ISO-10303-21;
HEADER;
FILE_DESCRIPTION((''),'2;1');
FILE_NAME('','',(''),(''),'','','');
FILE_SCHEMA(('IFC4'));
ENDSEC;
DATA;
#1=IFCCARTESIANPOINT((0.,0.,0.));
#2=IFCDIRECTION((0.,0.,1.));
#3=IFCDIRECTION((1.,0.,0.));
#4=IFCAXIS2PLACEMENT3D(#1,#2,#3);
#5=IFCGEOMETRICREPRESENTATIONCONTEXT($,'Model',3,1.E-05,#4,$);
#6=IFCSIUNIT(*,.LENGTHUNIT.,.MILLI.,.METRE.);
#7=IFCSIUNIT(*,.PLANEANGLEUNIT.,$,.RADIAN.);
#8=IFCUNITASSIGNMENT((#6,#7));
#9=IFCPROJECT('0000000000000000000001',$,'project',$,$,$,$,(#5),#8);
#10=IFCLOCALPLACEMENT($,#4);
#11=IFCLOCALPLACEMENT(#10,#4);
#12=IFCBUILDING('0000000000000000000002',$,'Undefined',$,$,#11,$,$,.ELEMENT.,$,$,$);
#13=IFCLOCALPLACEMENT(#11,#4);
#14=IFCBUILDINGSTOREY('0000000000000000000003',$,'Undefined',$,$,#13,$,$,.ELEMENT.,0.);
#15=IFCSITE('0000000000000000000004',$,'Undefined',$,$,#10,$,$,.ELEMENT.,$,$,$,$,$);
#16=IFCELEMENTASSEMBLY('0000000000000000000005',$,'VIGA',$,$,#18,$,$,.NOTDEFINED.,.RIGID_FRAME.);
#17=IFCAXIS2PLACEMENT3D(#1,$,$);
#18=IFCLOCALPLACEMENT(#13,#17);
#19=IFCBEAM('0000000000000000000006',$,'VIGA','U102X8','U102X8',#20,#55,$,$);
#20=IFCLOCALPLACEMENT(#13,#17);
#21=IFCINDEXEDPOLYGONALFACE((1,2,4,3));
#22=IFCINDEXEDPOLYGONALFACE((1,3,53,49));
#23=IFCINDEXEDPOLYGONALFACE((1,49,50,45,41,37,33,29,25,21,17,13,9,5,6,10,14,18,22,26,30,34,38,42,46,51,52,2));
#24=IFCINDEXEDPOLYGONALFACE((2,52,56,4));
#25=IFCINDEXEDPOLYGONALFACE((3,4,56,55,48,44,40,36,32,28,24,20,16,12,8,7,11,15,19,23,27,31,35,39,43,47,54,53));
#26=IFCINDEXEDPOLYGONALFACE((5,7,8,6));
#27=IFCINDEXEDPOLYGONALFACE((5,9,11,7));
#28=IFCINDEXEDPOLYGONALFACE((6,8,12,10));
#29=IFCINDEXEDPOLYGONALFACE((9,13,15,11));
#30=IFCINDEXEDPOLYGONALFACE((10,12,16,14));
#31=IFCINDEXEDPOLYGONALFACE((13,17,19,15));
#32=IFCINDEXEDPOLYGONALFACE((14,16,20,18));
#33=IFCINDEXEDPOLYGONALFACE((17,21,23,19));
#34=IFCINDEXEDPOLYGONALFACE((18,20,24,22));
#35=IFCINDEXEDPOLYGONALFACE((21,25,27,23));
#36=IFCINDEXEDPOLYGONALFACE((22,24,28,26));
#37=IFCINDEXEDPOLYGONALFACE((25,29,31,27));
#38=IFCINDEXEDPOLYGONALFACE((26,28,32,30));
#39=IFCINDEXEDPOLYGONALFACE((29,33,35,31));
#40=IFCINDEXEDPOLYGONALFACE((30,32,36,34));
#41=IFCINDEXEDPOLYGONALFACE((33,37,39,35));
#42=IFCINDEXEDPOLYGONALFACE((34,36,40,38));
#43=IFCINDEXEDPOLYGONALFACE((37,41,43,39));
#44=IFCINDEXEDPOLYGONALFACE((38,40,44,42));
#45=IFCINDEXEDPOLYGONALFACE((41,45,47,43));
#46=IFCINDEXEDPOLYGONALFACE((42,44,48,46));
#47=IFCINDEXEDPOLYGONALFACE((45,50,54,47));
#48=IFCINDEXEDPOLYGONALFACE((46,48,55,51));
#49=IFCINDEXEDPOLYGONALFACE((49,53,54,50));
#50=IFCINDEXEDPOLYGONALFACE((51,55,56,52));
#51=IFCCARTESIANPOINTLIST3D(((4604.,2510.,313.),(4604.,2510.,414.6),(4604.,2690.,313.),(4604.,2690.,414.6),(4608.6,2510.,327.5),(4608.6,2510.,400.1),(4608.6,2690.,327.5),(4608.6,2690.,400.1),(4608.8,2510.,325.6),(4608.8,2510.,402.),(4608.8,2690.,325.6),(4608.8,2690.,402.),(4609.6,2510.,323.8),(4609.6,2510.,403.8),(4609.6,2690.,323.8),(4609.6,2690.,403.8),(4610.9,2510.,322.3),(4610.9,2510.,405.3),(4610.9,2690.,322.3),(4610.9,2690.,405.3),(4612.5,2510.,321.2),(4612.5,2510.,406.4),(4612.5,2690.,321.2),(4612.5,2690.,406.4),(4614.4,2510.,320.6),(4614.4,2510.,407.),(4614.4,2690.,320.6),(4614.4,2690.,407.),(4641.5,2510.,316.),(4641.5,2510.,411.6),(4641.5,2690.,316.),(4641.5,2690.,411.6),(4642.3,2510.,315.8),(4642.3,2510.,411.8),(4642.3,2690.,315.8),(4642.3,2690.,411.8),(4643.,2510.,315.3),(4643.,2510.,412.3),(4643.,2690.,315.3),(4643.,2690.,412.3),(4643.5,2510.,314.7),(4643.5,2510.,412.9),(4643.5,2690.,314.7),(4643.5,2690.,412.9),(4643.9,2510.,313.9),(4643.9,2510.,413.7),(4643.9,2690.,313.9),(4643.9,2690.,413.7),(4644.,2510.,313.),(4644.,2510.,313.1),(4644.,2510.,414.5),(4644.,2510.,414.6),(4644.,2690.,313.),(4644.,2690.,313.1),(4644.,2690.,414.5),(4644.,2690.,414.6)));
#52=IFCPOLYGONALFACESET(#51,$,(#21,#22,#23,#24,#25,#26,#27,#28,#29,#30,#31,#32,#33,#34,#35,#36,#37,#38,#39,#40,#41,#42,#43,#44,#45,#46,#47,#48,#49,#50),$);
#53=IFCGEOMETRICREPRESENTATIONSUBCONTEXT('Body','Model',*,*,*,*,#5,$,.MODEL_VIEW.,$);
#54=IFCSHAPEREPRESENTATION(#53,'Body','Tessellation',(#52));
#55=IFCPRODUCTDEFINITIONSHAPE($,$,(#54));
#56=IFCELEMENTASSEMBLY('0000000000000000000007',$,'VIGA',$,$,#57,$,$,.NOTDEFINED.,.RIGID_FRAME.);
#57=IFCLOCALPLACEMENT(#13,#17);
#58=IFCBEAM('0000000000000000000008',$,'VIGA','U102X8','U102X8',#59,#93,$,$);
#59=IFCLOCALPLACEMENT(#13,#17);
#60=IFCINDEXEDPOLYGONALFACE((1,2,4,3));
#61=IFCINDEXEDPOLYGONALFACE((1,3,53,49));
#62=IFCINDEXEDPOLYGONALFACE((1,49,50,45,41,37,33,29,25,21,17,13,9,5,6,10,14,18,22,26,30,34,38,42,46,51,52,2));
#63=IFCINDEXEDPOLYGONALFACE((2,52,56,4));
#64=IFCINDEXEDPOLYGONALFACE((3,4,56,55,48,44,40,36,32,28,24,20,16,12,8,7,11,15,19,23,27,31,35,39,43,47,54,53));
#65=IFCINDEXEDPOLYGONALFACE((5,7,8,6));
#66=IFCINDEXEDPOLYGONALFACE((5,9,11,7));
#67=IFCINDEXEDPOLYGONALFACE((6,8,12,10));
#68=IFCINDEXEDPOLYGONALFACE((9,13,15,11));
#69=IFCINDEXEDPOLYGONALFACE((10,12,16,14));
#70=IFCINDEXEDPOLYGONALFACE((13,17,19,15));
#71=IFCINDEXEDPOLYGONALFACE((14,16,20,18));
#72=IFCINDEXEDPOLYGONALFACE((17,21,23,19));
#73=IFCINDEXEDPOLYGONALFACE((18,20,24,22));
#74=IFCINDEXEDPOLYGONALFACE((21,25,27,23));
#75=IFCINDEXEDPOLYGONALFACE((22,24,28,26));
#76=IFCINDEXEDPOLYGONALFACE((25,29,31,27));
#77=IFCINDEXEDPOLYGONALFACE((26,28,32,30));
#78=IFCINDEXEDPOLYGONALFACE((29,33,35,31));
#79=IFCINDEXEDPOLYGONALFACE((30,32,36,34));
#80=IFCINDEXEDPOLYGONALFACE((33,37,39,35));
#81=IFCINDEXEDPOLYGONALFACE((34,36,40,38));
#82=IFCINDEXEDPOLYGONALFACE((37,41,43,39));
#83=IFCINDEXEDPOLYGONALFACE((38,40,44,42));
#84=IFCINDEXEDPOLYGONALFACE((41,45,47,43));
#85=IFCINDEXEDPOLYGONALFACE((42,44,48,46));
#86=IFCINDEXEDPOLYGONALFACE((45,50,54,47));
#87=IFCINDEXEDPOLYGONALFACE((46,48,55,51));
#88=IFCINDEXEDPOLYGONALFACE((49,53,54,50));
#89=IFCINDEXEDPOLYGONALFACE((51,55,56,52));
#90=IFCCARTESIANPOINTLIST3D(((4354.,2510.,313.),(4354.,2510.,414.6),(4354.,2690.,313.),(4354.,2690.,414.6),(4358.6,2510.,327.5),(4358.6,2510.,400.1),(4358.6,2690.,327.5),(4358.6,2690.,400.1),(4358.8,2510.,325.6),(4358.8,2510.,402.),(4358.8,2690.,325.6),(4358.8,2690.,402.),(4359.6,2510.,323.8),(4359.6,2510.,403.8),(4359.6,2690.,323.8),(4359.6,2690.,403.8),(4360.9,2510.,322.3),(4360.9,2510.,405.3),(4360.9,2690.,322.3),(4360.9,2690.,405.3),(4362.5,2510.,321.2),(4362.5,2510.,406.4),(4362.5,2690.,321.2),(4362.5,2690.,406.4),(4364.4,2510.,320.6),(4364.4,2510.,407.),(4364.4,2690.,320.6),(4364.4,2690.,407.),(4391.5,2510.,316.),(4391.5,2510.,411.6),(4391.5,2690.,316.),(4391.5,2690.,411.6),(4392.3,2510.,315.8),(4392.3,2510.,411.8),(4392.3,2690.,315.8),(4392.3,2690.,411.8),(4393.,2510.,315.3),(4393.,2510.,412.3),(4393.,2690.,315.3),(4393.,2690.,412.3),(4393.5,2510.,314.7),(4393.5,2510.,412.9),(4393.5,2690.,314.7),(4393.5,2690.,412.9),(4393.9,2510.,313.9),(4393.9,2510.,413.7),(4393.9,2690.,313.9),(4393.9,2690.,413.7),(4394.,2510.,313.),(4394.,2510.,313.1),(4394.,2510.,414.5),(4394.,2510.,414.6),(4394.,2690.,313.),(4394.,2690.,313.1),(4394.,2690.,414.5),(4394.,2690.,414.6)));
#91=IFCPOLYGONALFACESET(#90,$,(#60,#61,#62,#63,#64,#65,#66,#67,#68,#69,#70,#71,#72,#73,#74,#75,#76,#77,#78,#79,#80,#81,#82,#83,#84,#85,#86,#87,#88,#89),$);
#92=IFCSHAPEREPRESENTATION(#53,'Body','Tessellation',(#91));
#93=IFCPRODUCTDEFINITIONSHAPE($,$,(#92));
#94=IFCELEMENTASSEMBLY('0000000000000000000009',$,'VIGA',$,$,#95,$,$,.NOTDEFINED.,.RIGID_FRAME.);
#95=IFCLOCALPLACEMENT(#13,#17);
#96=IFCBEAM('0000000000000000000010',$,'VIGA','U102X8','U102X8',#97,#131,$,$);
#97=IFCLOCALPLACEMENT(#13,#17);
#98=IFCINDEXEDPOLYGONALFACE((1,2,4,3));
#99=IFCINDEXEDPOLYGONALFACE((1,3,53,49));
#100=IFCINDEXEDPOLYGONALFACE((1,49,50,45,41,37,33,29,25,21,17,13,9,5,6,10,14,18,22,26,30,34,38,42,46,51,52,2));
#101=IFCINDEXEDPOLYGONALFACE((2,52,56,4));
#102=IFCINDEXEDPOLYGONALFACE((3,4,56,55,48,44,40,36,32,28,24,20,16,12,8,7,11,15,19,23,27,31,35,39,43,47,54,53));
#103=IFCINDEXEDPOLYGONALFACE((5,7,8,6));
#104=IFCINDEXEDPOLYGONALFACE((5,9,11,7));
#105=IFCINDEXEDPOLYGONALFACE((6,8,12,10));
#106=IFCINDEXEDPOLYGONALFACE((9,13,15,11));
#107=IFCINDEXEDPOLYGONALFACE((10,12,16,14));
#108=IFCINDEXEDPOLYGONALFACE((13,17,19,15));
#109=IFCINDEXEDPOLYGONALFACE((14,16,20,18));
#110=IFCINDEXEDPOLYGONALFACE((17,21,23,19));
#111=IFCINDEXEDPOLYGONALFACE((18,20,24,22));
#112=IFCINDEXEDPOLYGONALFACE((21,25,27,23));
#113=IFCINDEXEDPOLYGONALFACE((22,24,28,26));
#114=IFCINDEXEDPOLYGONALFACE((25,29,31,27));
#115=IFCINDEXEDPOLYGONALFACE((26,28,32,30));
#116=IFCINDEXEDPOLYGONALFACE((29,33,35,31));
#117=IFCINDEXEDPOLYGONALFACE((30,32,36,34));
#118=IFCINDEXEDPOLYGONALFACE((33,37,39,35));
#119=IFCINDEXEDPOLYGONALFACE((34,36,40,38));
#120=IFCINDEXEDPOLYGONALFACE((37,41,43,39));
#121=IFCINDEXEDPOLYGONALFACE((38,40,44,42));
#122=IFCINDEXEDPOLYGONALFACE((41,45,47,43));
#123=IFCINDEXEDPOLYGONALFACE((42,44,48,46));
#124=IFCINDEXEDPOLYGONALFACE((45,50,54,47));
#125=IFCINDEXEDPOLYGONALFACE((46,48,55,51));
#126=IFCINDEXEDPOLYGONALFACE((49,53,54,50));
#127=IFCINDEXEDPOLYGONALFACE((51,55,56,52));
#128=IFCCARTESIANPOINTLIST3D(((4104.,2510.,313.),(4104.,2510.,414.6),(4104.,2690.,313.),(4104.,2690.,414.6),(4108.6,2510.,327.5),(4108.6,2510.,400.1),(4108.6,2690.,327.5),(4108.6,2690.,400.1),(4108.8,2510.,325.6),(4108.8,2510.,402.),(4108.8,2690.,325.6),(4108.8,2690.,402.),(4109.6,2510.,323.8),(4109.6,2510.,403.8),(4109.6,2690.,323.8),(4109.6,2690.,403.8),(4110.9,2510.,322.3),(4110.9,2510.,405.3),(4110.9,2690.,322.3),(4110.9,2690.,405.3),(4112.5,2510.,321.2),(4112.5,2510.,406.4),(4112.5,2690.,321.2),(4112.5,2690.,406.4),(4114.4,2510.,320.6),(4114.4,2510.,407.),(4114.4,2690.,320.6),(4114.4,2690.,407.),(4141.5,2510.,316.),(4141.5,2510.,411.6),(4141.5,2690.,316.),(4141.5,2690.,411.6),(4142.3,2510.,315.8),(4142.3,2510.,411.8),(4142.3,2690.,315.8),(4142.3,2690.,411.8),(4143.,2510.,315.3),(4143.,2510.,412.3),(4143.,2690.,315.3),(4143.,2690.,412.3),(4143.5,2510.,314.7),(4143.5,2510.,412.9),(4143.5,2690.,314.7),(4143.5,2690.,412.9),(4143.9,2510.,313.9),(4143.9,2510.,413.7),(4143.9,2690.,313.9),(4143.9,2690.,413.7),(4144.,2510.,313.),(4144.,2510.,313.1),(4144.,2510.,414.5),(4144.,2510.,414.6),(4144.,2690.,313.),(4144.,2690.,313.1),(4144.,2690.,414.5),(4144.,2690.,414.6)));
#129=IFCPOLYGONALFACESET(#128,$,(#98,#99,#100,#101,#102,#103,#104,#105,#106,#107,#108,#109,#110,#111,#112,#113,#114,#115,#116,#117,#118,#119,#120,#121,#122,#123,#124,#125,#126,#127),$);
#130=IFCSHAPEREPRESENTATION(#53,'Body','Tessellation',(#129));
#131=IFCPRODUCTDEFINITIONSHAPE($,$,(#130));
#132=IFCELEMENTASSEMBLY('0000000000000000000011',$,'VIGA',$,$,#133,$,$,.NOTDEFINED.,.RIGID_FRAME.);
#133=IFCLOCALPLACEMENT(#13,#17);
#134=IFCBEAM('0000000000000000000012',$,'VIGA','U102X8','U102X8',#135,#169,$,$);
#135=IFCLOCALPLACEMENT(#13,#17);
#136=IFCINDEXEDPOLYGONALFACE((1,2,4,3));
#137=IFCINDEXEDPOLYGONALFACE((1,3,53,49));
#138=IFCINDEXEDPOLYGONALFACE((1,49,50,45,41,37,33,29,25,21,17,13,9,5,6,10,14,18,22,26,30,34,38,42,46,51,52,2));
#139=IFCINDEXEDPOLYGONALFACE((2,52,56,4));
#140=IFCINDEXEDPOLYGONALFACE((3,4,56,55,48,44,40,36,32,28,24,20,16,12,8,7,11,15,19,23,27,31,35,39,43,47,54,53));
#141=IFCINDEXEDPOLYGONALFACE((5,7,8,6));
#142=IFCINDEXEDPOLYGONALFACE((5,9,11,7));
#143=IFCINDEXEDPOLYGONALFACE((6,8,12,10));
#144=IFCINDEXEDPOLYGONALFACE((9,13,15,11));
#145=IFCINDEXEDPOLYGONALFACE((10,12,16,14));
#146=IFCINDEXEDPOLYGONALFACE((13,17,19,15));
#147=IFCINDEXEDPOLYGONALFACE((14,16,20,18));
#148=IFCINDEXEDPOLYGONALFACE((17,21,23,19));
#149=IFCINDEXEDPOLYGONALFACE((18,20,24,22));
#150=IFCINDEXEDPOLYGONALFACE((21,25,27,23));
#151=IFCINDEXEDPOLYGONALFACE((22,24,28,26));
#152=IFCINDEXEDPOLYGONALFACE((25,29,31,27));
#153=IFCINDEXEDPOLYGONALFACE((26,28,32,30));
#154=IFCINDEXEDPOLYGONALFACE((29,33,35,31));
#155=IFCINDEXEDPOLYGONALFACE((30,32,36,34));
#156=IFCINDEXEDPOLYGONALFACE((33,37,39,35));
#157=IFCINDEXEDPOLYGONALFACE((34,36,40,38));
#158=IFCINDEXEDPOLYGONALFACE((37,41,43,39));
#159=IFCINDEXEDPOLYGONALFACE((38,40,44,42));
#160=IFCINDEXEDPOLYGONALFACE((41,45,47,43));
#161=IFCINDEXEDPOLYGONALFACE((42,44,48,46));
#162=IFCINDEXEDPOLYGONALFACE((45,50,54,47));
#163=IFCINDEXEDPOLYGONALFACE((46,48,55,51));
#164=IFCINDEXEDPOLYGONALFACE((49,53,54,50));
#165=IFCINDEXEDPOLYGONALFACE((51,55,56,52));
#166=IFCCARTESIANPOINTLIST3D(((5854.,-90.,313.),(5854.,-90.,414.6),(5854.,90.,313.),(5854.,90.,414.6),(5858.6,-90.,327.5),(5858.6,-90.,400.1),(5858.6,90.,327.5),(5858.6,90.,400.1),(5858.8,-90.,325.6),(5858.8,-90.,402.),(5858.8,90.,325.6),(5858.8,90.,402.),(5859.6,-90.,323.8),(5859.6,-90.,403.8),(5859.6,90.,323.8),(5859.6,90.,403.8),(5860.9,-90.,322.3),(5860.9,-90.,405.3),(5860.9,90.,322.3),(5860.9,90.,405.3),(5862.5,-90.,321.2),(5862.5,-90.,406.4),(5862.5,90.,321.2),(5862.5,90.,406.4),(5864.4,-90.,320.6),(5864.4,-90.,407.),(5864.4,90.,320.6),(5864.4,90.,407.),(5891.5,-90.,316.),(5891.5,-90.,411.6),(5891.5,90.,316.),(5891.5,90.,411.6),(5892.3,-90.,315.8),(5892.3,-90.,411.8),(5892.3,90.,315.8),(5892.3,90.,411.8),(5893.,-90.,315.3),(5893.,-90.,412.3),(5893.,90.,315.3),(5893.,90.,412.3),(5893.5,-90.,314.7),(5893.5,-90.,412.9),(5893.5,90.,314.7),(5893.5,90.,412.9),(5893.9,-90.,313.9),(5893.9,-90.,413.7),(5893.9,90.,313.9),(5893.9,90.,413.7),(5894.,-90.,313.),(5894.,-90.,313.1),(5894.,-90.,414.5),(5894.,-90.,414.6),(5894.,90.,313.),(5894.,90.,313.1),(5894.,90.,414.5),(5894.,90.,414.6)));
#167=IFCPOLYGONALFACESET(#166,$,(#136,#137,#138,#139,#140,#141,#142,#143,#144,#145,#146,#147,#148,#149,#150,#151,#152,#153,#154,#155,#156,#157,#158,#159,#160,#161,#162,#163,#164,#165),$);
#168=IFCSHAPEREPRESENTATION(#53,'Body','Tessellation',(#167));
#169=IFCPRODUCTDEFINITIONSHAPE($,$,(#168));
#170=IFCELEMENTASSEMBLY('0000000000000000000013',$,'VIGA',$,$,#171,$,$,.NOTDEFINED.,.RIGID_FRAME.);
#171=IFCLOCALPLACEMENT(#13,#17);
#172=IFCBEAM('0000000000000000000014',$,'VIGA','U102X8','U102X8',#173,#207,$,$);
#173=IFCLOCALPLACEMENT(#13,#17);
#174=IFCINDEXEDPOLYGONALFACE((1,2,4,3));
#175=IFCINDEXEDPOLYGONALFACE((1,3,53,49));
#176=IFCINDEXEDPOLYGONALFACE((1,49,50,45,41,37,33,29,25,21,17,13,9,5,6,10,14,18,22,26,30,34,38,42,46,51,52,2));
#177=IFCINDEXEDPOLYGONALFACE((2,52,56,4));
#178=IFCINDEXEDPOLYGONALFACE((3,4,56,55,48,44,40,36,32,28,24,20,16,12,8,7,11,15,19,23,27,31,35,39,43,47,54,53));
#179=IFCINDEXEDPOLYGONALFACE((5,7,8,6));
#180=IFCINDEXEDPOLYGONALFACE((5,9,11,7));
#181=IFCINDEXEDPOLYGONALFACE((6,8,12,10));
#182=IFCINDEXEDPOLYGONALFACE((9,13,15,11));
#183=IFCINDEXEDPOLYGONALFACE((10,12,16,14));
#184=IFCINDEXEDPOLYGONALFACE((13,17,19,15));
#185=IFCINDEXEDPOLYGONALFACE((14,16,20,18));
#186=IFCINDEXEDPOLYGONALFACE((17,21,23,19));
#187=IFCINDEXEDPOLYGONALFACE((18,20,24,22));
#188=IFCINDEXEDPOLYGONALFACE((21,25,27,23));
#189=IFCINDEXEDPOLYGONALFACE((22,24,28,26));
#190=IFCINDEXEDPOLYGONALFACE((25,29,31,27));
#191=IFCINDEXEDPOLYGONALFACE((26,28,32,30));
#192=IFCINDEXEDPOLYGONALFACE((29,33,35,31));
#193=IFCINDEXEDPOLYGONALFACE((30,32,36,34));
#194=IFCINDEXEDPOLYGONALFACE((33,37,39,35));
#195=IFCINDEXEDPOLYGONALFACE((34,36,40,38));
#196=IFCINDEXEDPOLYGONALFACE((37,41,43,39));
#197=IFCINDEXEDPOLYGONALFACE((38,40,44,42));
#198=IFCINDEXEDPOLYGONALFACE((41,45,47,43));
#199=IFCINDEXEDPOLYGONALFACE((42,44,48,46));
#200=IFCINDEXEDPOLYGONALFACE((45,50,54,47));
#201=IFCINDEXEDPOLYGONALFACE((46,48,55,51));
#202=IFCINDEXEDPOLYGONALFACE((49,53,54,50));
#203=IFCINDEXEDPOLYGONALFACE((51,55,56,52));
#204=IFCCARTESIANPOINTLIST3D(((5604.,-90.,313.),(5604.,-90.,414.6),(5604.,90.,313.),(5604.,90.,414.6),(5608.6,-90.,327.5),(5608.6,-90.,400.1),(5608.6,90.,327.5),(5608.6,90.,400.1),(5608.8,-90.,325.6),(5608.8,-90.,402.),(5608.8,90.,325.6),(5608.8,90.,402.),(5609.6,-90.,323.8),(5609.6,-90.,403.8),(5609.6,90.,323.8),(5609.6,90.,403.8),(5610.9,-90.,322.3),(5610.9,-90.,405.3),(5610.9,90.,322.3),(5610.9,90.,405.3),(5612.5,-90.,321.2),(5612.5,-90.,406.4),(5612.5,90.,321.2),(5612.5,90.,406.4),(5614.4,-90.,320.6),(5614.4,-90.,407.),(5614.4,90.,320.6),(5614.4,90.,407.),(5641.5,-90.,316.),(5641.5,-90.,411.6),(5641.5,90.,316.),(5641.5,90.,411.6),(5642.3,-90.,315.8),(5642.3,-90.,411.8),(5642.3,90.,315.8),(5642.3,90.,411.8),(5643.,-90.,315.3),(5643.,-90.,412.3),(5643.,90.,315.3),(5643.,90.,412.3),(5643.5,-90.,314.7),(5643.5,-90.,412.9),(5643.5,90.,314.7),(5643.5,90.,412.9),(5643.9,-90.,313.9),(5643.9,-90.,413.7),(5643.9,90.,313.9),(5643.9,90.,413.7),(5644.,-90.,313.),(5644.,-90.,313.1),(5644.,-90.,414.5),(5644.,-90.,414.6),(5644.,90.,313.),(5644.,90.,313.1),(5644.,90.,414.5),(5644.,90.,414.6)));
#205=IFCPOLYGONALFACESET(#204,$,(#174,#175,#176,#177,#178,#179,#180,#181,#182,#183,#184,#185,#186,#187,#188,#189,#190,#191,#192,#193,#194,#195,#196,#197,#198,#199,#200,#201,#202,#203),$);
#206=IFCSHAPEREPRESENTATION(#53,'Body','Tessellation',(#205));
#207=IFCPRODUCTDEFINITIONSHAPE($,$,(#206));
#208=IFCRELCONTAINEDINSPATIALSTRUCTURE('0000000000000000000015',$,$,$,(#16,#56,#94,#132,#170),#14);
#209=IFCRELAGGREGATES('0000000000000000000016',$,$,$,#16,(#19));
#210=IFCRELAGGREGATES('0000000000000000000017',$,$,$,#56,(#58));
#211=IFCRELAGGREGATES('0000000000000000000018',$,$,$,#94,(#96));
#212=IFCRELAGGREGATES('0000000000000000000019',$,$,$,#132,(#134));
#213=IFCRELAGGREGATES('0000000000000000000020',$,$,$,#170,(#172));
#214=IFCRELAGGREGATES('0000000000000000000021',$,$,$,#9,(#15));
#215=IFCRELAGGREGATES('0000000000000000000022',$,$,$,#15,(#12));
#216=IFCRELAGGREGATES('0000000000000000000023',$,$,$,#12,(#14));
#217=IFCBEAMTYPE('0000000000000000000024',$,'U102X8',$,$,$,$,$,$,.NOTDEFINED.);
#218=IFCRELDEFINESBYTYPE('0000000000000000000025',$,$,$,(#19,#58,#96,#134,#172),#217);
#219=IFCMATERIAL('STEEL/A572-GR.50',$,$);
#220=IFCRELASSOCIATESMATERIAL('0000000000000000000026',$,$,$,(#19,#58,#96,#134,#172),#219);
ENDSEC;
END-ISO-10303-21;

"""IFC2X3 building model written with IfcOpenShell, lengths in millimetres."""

from ifc_helpers import new_model, si_unit, frame, origin_with_axes, origin_2d_with_axis, place, context, subcontext, project, spatial, u_section, extrude, material, type_object, element, aggregate, save


model = new_model("IFC2X3")

# Units and contexts
model_context = context("Model", 3, precision=1e-05, world=origin_with_axes())
body_context = subcontext(model_context, "Body", "Model", "MODEL_VIEW")
ifc_project = project(units=[si_unit("LENGTHUNIT", "METRE", prefix="MILLI"), si_unit("PLANEANGLEUNIT", "RADIAN")], contexts=[model_context])

# Site, building, storey
site_placement = place(None, origin_with_axes())
site = spatial("IfcSite", under=ifc_project, at=site_placement, Name="Undefined", CompositionType="ELEMENT")
building_placement = place(site_placement, origin_with_axes())
building = spatial("IfcBuilding", under=site, at=building_placement, Name="Undefined", CompositionType="ELEMENT")
storey_placement = place(building_placement, origin_with_axes())
storey = spatial("IfcBuildingStorey", under=building, at=storey_placement, Name="Undefined", CompositionType="ELEMENT", Elevation=0.0)

# Element assemblies, beams
ifc_material = material(Name="STEEL/A572-GR.50")
beam_type = type_object("IfcBeamType", Name="U102X8", PredefinedType="NOTDEFINED")
assembly_1_placement = place(storey_placement, origin_with_axes())
assembly_1 = element("IfcElementAssembly", 1, at=assembly_1_placement, inside=storey, Name="VIGA", AssemblyPlace="NOTDEFINED", PredefinedType="RIGID_FRAME")
beam_1_placement = place(assembly_1_placement, frame((4624.0, 2510.0, 363.8), z_axis=(0.0, 0.0, 1.0), x_axis=(0.0, 1.0, 0.0)))
beam_1 = element("IfcBeam", 2, at=beam_1_placement, type_object=beam_type, material=ifc_material, Name="VIGA", Description="U102X8", ObjectType="U102X8", context=body_context, shape_type="SweptSolid", body=[
    extrude(u_section(Depth=101.6, FlangeWidth=40.0, WebThickness=4.6, FlangeThickness=6.0, FilletRadius=7.0, EdgeRadius=3.0, FlangeSlope=0.16839, at=origin_2d_with_axis()), frame((180.0, 0.0, 0.0), z_axis=(-1.0, 0.0, 0.0), x_axis=(0.0, -1.0, 0.0)), (0.0, 0.0, 1.0), 180.0),
])
aggregate(assembly_1, [beam_1])
assembly_2_placement = place(storey_placement, origin_with_axes())
assembly_2 = element("IfcElementAssembly", 3, at=assembly_2_placement, inside=storey, Name="VIGA", AssemblyPlace="NOTDEFINED", PredefinedType="RIGID_FRAME")
beam_2_placement = place(assembly_2_placement, frame((4374.0, 2510.0, 363.8), z_axis=(0.0, 0.0, 1.0), x_axis=(0.0, 1.0, 0.0)))
beam_2 = element("IfcBeam", 4, at=beam_2_placement, type_object=beam_type, material=ifc_material, Name="VIGA", Description="U102X8", ObjectType="U102X8", context=body_context, shape_type="SweptSolid", body=[
    extrude(u_section(Depth=101.6, FlangeWidth=40.0, WebThickness=4.6, FlangeThickness=6.0, FilletRadius=7.0, EdgeRadius=3.0, FlangeSlope=0.16839, at=origin_2d_with_axis()), frame((180.0, 0.0, 0.0), z_axis=(-1.0, 0.0, 0.0), x_axis=(0.0, -1.0, 0.0)), (0.0, 0.0, 1.0), 180.0),
])
aggregate(assembly_2, [beam_2])
assembly_3_placement = place(storey_placement, origin_with_axes())
assembly_3 = element("IfcElementAssembly", 5, at=assembly_3_placement, inside=storey, Name="VIGA", AssemblyPlace="NOTDEFINED", PredefinedType="RIGID_FRAME")
beam_3_placement = place(assembly_3_placement, frame((4124.0, 2510.0, 363.8), z_axis=(0.0, 0.0, 1.0), x_axis=(0.0, 1.0, 0.0)))
beam_3 = element("IfcBeam", 6, at=beam_3_placement, type_object=beam_type, material=ifc_material, Name="VIGA", Description="U102X8", ObjectType="U102X8", context=body_context, shape_type="SweptSolid", body=[
    extrude(u_section(Depth=101.6, FlangeWidth=40.0, WebThickness=4.6, FlangeThickness=6.0, FilletRadius=7.0, EdgeRadius=3.0, FlangeSlope=0.16839, at=origin_2d_with_axis()), frame((180.0, 0.0, 0.0), z_axis=(-1.0, 0.0, 0.0), x_axis=(0.0, -1.0, 0.0)), (0.0, 0.0, 1.0), 180.0),
])
aggregate(assembly_3, [beam_3])
assembly_4_placement = place(storey_placement, origin_with_axes())
assembly_4 = element("IfcElementAssembly", 7, at=assembly_4_placement, inside=storey, Name="VIGA", AssemblyPlace="NOTDEFINED", PredefinedType="RIGID_FRAME")
beam_4_placement = place(assembly_4_placement, frame((5874.0, -90.0, 363.8), z_axis=(0.0, 0.0, 1.0), x_axis=(0.0, 1.0, 0.0)))
beam_4 = element("IfcBeam", 8, at=beam_4_placement, type_object=beam_type, material=ifc_material, Name="VIGA", Description="U102X8", ObjectType="U102X8", context=body_context, shape_type="SweptSolid", body=[
    extrude(u_section(Depth=101.6, FlangeWidth=40.0, WebThickness=4.6, FlangeThickness=6.0, FilletRadius=7.0, EdgeRadius=3.0, FlangeSlope=0.16839, at=origin_2d_with_axis()), frame((180.0, 0.0, 0.0), z_axis=(-1.0, 0.0, 0.0), x_axis=(0.0, -1.0, 0.0)), (0.0, 0.0, 1.0), 180.0),
])
aggregate(assembly_4, [beam_4])
assembly_5_placement = place(storey_placement, origin_with_axes())
assembly_5 = element("IfcElementAssembly", 9, at=assembly_5_placement, inside=storey, Name="VIGA", AssemblyPlace="NOTDEFINED", PredefinedType="RIGID_FRAME")
beam_5_placement = place(assembly_5_placement, frame((5624.0, -90.0, 363.8), z_axis=(0.0, 0.0, 1.0), x_axis=(0.0, 1.0, 0.0)))
beam_5 = element("IfcBeam", 10, at=beam_5_placement, type_object=beam_type, material=ifc_material, Name="VIGA", Description="U102X8", ObjectType="U102X8", context=body_context, shape_type="SweptSolid", body=[
    extrude(u_section(Depth=101.6, FlangeWidth=40.0, WebThickness=4.6, FlangeThickness=6.0, FilletRadius=7.0, EdgeRadius=3.0, FlangeSlope=0.16839, at=origin_2d_with_axis()), frame((180.0, 0.0, 0.0), z_axis=(-1.0, 0.0, 0.0), x_axis=(0.0, -1.0, 0.0)), (0.0, 0.0, 1.0), 180.0),
])
aggregate(assembly_5, [beam_5])

save(model, "model.ifc")
